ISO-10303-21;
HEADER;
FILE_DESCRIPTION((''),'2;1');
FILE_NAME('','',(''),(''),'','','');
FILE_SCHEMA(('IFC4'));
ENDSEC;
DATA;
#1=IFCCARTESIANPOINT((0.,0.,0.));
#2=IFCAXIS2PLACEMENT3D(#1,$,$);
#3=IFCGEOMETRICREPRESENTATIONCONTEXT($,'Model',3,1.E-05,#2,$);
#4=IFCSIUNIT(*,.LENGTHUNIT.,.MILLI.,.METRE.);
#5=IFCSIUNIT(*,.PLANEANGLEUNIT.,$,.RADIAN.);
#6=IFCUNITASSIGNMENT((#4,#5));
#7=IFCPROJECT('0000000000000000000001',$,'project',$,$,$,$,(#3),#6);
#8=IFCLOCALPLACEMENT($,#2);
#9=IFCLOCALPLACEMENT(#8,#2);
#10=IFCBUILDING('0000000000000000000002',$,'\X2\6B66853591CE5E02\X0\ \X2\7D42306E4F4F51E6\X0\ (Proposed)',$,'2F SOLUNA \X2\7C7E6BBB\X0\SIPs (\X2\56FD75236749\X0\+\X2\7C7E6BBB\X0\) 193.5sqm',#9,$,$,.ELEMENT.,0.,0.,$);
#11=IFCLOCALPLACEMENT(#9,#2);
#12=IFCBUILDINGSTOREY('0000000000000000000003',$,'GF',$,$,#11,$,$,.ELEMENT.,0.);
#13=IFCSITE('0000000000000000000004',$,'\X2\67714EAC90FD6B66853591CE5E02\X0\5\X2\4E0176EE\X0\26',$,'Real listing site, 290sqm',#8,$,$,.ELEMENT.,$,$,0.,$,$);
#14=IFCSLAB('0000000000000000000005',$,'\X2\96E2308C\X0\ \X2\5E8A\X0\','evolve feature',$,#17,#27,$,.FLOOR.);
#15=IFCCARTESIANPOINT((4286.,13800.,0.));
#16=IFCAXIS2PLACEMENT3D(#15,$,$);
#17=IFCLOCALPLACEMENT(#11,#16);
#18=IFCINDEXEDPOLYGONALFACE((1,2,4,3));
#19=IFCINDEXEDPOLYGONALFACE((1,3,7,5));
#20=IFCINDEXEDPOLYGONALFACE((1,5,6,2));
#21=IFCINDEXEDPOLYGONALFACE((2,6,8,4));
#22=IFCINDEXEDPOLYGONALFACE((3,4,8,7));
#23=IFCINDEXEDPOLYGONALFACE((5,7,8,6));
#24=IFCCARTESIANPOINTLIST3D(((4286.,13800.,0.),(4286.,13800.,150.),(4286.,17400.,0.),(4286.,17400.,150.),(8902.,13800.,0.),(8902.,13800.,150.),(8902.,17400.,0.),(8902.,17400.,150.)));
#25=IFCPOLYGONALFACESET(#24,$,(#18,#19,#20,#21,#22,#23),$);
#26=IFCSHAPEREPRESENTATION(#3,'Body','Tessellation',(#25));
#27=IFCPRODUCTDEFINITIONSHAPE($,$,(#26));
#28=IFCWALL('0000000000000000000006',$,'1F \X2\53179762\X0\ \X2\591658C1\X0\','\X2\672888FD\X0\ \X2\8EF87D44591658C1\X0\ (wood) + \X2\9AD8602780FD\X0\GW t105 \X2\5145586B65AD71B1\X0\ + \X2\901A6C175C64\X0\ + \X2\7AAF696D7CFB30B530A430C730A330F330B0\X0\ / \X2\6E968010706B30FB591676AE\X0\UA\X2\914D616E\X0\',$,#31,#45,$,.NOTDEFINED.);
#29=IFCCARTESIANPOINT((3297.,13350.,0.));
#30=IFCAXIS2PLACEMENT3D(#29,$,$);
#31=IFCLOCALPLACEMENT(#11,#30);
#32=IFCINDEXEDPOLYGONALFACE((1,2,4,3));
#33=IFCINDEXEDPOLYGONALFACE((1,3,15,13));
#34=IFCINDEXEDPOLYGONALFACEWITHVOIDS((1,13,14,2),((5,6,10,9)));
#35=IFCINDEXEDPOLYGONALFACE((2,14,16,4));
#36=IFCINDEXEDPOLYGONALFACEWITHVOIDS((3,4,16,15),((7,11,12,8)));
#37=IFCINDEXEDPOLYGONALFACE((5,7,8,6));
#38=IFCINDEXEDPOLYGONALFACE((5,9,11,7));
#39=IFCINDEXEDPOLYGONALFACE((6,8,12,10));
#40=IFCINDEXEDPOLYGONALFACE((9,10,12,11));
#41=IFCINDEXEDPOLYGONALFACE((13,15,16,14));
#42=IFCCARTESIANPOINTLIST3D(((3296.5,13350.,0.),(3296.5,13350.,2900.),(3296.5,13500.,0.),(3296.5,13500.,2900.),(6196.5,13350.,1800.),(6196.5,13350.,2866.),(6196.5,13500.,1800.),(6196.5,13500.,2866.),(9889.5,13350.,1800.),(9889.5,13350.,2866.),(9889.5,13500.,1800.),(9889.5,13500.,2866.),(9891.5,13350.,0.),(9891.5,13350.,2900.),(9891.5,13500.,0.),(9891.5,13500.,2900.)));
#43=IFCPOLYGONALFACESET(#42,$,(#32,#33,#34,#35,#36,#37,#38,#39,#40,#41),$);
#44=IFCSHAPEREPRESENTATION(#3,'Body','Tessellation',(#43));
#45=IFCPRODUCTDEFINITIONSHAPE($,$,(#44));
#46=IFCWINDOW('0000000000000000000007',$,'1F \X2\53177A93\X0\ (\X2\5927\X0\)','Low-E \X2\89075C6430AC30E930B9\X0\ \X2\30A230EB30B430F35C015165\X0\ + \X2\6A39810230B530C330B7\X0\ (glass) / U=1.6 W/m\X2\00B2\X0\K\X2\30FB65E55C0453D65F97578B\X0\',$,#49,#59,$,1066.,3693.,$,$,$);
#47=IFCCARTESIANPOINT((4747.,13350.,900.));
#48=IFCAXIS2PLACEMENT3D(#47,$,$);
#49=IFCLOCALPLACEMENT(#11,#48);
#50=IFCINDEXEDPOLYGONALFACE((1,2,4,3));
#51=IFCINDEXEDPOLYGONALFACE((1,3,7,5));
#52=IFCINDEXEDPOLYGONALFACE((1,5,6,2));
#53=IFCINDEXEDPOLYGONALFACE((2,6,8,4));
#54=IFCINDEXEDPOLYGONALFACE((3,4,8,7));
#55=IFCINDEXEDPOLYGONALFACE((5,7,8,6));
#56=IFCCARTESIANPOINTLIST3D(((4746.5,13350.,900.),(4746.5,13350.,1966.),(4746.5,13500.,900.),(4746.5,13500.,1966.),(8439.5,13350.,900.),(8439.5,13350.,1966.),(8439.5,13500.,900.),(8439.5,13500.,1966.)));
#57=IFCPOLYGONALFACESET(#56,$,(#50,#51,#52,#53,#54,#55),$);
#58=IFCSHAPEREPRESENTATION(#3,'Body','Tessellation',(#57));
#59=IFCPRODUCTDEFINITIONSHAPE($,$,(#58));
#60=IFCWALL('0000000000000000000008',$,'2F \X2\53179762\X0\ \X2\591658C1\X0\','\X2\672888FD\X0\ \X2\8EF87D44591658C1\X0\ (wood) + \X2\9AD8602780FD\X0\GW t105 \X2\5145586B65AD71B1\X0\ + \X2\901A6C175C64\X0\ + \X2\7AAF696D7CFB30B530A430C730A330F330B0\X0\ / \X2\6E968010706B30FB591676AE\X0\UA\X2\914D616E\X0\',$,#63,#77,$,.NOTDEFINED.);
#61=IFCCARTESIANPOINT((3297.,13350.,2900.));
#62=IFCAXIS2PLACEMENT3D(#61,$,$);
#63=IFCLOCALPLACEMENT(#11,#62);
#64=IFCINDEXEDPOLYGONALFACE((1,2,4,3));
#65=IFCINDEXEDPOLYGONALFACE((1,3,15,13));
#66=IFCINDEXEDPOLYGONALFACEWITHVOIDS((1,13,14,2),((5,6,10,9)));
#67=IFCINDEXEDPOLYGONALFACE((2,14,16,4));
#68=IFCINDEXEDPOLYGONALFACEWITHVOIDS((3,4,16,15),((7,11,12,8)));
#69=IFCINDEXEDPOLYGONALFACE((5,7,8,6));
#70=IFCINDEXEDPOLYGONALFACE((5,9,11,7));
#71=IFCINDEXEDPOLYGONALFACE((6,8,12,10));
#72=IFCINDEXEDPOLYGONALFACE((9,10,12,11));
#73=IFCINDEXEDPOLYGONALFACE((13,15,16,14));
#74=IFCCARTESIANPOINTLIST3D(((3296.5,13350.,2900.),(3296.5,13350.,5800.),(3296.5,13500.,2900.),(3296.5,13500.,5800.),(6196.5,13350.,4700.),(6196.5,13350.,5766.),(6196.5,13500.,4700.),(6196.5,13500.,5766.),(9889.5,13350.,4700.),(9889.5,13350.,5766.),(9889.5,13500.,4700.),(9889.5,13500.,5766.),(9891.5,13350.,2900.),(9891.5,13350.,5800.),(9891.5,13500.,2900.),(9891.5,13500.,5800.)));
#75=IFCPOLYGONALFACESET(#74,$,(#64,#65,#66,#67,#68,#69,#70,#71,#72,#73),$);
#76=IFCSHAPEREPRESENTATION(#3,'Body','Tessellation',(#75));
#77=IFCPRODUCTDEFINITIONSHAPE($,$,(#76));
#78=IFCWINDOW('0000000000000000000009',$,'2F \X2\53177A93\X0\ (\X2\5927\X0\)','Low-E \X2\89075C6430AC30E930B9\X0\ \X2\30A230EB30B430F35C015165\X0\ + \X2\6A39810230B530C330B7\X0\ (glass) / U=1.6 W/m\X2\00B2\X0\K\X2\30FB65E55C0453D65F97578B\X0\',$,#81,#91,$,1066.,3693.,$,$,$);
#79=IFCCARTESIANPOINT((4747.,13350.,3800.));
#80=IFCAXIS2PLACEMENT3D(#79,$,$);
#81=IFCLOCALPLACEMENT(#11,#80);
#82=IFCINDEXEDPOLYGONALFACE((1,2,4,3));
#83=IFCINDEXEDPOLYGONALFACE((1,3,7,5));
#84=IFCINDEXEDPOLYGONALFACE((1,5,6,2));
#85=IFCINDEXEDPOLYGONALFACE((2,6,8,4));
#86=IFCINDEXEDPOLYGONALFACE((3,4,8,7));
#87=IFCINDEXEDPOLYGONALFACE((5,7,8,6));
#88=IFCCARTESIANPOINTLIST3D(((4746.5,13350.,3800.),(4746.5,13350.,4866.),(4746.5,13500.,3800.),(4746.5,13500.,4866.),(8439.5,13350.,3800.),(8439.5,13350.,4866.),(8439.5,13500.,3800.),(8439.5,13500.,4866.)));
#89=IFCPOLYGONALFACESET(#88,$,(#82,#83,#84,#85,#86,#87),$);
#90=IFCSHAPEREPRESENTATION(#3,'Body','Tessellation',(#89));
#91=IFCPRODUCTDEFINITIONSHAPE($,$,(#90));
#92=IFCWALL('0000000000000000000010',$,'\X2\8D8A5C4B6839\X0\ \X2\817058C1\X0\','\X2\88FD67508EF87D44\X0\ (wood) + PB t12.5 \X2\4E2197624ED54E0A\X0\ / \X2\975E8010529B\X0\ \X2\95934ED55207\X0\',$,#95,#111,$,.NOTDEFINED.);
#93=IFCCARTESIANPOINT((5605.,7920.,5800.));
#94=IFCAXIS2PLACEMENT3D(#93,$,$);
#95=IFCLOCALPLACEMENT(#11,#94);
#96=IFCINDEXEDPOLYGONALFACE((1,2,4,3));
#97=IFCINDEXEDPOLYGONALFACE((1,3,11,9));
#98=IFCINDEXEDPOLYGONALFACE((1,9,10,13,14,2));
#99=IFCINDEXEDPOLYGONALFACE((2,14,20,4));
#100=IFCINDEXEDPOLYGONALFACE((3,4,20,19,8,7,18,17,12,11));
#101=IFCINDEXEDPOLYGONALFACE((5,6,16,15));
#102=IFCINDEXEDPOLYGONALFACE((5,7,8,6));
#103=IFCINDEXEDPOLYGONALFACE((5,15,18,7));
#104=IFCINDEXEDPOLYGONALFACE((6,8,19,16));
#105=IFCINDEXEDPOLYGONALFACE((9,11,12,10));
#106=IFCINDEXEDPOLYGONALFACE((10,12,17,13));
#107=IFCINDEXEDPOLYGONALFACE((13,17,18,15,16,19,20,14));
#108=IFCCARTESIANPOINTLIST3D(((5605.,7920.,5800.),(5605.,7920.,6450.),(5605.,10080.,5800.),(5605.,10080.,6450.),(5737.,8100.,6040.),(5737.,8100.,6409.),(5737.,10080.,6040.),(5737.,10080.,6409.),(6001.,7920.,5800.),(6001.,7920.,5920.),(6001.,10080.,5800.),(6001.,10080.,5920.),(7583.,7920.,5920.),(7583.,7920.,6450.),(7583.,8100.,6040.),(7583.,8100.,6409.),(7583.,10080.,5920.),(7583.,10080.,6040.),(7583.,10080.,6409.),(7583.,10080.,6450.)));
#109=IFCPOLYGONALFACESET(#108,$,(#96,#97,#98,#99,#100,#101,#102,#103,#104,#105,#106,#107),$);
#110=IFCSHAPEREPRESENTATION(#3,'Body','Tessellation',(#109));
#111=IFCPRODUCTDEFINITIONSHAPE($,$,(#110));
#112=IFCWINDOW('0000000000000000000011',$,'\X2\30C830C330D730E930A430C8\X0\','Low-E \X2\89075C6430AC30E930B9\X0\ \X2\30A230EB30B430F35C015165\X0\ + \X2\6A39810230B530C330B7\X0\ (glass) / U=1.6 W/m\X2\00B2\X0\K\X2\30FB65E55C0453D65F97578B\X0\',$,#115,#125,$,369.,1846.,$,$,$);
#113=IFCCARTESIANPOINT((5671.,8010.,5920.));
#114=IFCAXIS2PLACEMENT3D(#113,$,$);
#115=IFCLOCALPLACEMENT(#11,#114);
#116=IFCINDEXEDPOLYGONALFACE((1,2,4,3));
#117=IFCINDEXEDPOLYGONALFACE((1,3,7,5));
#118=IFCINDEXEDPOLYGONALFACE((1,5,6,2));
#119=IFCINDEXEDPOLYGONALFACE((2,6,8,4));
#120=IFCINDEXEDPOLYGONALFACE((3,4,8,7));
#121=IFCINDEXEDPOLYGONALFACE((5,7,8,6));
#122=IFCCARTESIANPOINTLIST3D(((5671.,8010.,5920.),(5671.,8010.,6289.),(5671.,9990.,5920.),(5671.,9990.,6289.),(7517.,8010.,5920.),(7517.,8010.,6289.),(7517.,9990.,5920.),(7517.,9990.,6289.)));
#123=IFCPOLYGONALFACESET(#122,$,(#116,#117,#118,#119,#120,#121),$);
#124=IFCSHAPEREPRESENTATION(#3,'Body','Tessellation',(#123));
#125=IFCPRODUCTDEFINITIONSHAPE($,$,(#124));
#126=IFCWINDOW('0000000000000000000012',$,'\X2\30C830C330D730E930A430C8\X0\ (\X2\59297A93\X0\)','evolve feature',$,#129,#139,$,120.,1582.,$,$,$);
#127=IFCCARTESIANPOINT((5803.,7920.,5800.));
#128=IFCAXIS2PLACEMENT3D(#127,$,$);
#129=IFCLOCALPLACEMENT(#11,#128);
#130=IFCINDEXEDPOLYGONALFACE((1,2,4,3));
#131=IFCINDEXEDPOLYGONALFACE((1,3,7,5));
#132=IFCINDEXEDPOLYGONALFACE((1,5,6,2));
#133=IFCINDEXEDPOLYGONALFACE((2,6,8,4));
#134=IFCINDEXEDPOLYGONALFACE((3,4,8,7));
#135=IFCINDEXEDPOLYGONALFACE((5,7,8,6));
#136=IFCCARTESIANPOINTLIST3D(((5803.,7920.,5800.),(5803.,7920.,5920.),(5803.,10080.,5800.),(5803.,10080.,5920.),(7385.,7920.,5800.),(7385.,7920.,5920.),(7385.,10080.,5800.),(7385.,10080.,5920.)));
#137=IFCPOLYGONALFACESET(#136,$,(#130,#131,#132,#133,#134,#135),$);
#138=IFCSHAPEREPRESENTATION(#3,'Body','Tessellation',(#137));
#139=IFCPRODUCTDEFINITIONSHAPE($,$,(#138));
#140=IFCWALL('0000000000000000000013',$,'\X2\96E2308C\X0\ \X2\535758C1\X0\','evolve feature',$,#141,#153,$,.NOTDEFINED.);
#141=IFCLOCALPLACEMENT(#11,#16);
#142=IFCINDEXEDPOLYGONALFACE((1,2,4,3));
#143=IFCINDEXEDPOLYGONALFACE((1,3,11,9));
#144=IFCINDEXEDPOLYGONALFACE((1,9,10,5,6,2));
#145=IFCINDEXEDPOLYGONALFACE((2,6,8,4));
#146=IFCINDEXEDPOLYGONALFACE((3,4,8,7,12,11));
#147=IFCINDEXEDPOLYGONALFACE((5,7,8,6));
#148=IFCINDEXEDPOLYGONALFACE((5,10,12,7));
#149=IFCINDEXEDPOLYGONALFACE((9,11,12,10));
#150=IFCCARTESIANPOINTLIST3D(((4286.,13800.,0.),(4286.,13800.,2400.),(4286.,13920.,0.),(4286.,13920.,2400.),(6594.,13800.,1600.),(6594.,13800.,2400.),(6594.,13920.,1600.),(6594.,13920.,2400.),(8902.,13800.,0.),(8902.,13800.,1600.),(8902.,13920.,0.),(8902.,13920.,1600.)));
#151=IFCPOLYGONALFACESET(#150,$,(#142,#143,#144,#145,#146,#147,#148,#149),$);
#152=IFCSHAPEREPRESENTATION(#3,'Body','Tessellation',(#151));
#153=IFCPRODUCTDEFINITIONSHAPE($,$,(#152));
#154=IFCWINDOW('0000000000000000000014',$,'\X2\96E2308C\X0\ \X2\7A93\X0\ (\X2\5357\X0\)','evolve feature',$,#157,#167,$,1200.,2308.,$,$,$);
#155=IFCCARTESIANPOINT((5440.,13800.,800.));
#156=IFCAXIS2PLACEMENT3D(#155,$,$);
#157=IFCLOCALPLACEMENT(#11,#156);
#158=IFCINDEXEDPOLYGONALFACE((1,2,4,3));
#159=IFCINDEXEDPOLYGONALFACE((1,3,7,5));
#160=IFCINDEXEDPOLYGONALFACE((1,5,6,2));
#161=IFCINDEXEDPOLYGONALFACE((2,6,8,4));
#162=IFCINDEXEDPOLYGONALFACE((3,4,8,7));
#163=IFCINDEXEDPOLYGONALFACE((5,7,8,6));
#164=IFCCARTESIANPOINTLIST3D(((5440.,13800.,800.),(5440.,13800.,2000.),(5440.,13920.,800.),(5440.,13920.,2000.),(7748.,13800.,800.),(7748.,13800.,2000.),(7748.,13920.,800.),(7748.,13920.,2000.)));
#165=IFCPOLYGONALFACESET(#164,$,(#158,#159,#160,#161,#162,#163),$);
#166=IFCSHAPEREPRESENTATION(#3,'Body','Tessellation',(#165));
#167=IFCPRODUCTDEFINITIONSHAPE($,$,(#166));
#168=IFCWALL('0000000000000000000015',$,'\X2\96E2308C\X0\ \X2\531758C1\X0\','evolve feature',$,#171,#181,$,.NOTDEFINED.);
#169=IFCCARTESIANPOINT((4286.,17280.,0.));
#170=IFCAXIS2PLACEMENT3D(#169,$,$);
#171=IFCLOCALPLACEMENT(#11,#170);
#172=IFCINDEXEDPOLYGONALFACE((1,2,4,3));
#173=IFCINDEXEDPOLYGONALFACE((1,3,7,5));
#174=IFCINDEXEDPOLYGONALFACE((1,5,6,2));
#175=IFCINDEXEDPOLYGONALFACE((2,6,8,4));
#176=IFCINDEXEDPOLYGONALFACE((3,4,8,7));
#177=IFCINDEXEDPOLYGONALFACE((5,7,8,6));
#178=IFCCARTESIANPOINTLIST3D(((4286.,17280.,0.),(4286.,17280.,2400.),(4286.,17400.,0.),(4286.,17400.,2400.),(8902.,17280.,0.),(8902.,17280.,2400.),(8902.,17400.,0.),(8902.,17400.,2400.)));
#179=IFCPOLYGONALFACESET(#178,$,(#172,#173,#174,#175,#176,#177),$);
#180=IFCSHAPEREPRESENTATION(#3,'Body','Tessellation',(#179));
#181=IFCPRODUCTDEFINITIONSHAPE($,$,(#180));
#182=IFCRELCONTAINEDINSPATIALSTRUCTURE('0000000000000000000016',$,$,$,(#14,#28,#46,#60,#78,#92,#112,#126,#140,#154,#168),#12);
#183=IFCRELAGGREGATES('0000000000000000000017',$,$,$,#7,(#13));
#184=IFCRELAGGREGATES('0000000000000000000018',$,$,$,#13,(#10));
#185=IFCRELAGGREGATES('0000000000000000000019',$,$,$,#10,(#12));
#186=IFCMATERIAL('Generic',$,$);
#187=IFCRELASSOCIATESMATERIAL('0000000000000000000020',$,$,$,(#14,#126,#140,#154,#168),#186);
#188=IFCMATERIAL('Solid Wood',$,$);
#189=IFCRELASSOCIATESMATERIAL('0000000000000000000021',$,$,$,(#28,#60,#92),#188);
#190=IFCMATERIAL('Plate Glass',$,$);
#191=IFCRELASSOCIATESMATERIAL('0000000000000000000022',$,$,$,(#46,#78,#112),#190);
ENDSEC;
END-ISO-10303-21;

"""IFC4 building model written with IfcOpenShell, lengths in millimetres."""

from ifc_helpers import new_model, si_unit, frame, frame_2d, origin, place, context, project, spatial, rectangle, extrude, material, element, fill, save


model = new_model("IFC4")

# Units and contexts
model_context = context("Model", 3, precision=1e-05, world=origin())
ifc_project = project(units=[si_unit("LENGTHUNIT", "METRE", prefix="MILLI"), si_unit("PLANEANGLEUNIT", "RADIAN")], contexts=[model_context])

# Site, building, storey
site_placement = place(None, origin())
site = spatial("IfcSite", under=ifc_project, at=site_placement, Name="東京都武蔵野市5丁目26", ObjectType="Real listing site, 290sqm", CompositionType="ELEMENT", RefElevation=0.0)
building_placement = place(site_placement, origin())
building = spatial("IfcBuilding", under=site, at=building_placement, Name="武蔵野市 終の住処 (Proposed)", ObjectType="2F SOLUNA 籾殻SIPs (国産杉+籾殻) 193.5sqm", CompositionType="ELEMENT", ElevationOfRefHeight=0.0, ElevationOfTerrain=0.0)
storey_placement = place(building_placement, origin())
storey = spatial("IfcBuildingStorey", under=building, at=storey_placement, Name="GF", CompositionType="ELEMENT", Elevation=0.0)

# Slab
ifc_material_1 = material(Name="Generic")
slab_placement = place(storey_placement, frame((4286.0, 13800.0, 0.0)))
element("IfcSlab", 1, at=slab_placement, inside=storey, material=ifc_material_1, Name="離れ 床", Description="evolve feature", PredefinedType="FLOOR", context=model_context, shape_type="SweptSolid", body=[
    extrude(rectangle(XDim=4616.0, YDim=3600.0, at=frame_2d((2308.0, 1800.0))), frame((4286.0, 13800.0, 0.0)), (0.0, 0.0, 1.0), 150.0),
])

# Wall, opening, window
ifc_material_2 = material(Name="Solid Wood")
wall_1_placement = place(storey_placement, frame((3297.0, 13350.0, 0.0)))
wall_1 = element("IfcWall", 2, at=wall_1_placement, inside=storey, material=ifc_material_2, Name="1F 北面 外壁", Description="木製 軸組外壁 (wood) + 高性能GW t105 充填断熱 + 通気層 + 窯業系サイディング / 準耐火・外皮UA配慮", PredefinedType="NOTDEFINED", context=model_context, shape_type="SweptSolid", body=[
    extrude(rectangle(XDim=6595.0, YDim=150.0, at=frame_2d((3297.0, 75.0))), frame((3297.0, 13350.0, 0.0)), (0.0, 0.0, 1.0), 2900.0),
])
opening_1_placement = place(storey_placement, frame((4747.0, 13350.0, 900.0)))
opening_1 = element("IfcOpeningElement", 3, at=opening_1_placement, cuts=wall_1, PredefinedType="NOTDEFINED", context=model_context, shape_type="SweptSolid", body=[
    extrude(rectangle(XDim=3693.0, YDim=150.0, at=frame_2d((1846.0, 75.0))), frame((4747.0, 13350.0, 900.0)), (0.0, 0.0, 1.0), 1066.0),
])
ifc_material_3 = material(Name="Plate Glass")
window_1_placement = place(storey_placement, frame((4747.0, 13350.0, 900.0)))
window_1 = element("IfcWindow", 4, at=window_1_placement, inside=storey, material=ifc_material_3, Name="1F 北窓 (大)", Description="Low-E 複層ガラス アルゴン封入 + 樹脂サッシ (glass) / U=1.6 W/m²K・日射取得型", OverallHeight=1066.0, OverallWidth=3693.0, context=model_context, shape_type="SweptSolid", body=[
    extrude(rectangle(XDim=3693.0, YDim=150.0, at=frame_2d((1846.0, 75.0))), frame((4747.0, 13350.0, 900.0)), (0.0, 0.0, 1.0), 1066.0),
])
fill(opening_1, window_1)

# Wall, opening, window
wall_2_placement = place(storey_placement, frame((3297.0, 13350.0, 2900.0)))
wall_2 = element("IfcWall", 5, at=wall_2_placement, inside=storey, material=ifc_material_2, Name="2F 北面 外壁", Description="木製 軸組外壁 (wood) + 高性能GW t105 充填断熱 + 通気層 + 窯業系サイディング / 準耐火・外皮UA配慮", PredefinedType="NOTDEFINED", context=model_context, shape_type="SweptSolid", body=[
    extrude(rectangle(XDim=6595.0, YDim=150.0, at=frame_2d((3297.0, 75.0))), frame((3297.0, 13350.0, 2900.0)), (0.0, 0.0, 1.0), 2900.0),
])
opening_2_placement = place(storey_placement, frame((4747.0, 13350.0, 3800.0)))
opening_2 = element("IfcOpeningElement", 6, at=opening_2_placement, cuts=wall_2, PredefinedType="NOTDEFINED", context=model_context, shape_type="SweptSolid", body=[
    extrude(rectangle(XDim=3693.0, YDim=150.0, at=frame_2d((1846.0, 75.0))), frame((4747.0, 13350.0, 3800.0)), (0.0, 0.0, 1.0), 1066.0),
])
window_2_placement = place(storey_placement, frame((4747.0, 13350.0, 3800.0)))
window_2 = element("IfcWindow", 7, at=window_2_placement, inside=storey, material=ifc_material_3, Name="2F 北窓 (大)", Description="Low-E 複層ガラス アルゴン封入 + 樹脂サッシ (glass) / U=1.6 W/m²K・日射取得型", OverallHeight=1066.0, OverallWidth=3693.0, context=model_context, shape_type="SweptSolid", body=[
    extrude(rectangle(XDim=3693.0, YDim=150.0, at=frame_2d((1846.0, 75.0))), frame((4747.0, 13350.0, 3800.0)), (0.0, 0.0, 1.0), 1066.0),
])
fill(opening_2, window_2)

# Wall, openings, windows
wall_3_placement = place(storey_placement, frame((5605.0, 7920.0, 5800.0)))
wall_3 = element("IfcWall", 8, at=wall_3_placement, inside=storey, material=ifc_material_2, Name="越屋根 腰壁", Description="製材軸組 (wood) + PB t12.5 両面仕上 / 非耐力 間仕切", PredefinedType="NOTDEFINED", context=model_context, shape_type="SweptSolid", body=[
    extrude(rectangle(XDim=1978.0, YDim=2160.0, at=frame_2d((989.0, 1080.0))), frame((5605.0, 7920.0, 5800.0)), (0.0, 0.0, 1.0), 650.0),
])
opening_3_placement = place(storey_placement, frame((5671.0, 8010.0, 5920.0)))
opening_3 = element("IfcOpeningElement", 9, at=opening_3_placement, cuts=wall_3, PredefinedType="NOTDEFINED", context=model_context, shape_type="SweptSolid", body=[
    extrude(rectangle(XDim=1846.0, YDim=1980.0, at=frame_2d((923.0, 990.0))), frame((5671.0, 8010.0, 5920.0)), (0.0, 0.0, 1.0), 369.0),
])
opening_4_placement = place(storey_placement, frame((5803.0, 7920.0, 5800.0)))
opening_4 = element("IfcOpeningElement", 10, at=opening_4_placement, cuts=wall_3, PredefinedType="NOTDEFINED", context=model_context, shape_type="SweptSolid", body=[
    extrude(rectangle(XDim=1582.0, YDim=2160.0, at=frame_2d((791.0, 1080.0))), frame((5803.0, 7920.0, 5800.0)), (0.0, 0.0, 1.0), 120.0),
])
window_3_placement = place(storey_placement, frame((5671.0, 8010.0, 5920.0)))
window_3 = element("IfcWindow", 11, at=window_3_placement, inside=storey, material=ifc_material_3, Name="トップライト", Description="Low-E 複層ガラス アルゴン封入 + 樹脂サッシ (glass) / U=1.6 W/m²K・日射取得型", OverallHeight=369.0, OverallWidth=1846.0, context=model_context, shape_type="SweptSolid", body=[
    extrude(rectangle(XDim=1846.0, YDim=1980.0, at=frame_2d((923.0, 990.0))), frame((5671.0, 8010.0, 5920.0)), (0.0, 0.0, 1.0), 369.0),
])
fill(opening_3, window_3)
window_4_placement = place(storey_placement, frame((5803.0, 7920.0, 5800.0)))
window_4 = element("IfcWindow", 12, at=window_4_placement, inside=storey, material=ifc_material_1, Name="トップライト (天窓)", Description="evolve feature", OverallHeight=120.0, OverallWidth=1582.0, context=model_context, shape_type="SweptSolid", body=[
    extrude(rectangle(XDim=1582.0, YDim=2160.0, at=frame_2d((791.0, 1080.0))), frame((5803.0, 7920.0, 5800.0)), (0.0, 0.0, 1.0), 120.0),
])
fill(opening_4, window_4)

# Wall, opening, window
wall_4_placement = place(storey_placement, frame((4286.0, 13800.0, 0.0)))
wall_4 = element("IfcWall", 13, at=wall_4_placement, inside=storey, material=ifc_material_1, Name="離れ 南壁", Description="evolve feature", PredefinedType="NOTDEFINED", context=model_context, shape_type="SweptSolid", body=[
    extrude(rectangle(XDim=4616.0, YDim=120.0, at=frame_2d((2308.0, 60.0))), frame((4286.0, 13800.0, 0.0)), (0.0, 0.0, 1.0), 2400.0),
])
opening_5_placement = place(storey_placement, frame((5440.0, 13800.0, 800.0)))
opening_5 = element("IfcOpeningElement", 14, at=opening_5_placement, cuts=wall_4, PredefinedType="NOTDEFINED", context=model_context, shape_type="SweptSolid", body=[
    extrude(rectangle(XDim=2308.0, YDim=120.0, at=frame_2d((1154.0, 60.0))), frame((5440.0, 13800.0, 800.0)), (0.0, 0.0, 1.0), 1200.0),
])
window_5_placement = place(storey_placement, frame((5440.0, 13800.0, 800.0)))
window_5 = element("IfcWindow", 15, at=window_5_placement, inside=storey, material=ifc_material_1, Name="離れ 窓 (南)", Description="evolve feature", OverallHeight=1200.0, OverallWidth=2308.0, context=model_context, shape_type="SweptSolid", body=[
    extrude(rectangle(XDim=2308.0, YDim=120.0, at=frame_2d((1154.0, 60.0))), frame((5440.0, 13800.0, 800.0)), (0.0, 0.0, 1.0), 1200.0),
])
fill(opening_5, window_5)

# Wall
wall_5_placement = place(storey_placement, frame((4286.0, 17280.0, 0.0)))
element("IfcWall", 16, at=wall_5_placement, inside=storey, material=ifc_material_1, Name="離れ 北壁", Description="evolve feature", PredefinedType="NOTDEFINED", context=model_context, shape_type="SweptSolid", body=[
    extrude(rectangle(XDim=4616.0, YDim=120.0, at=frame_2d((2308.0, 60.0))), frame((4286.0, 17280.0, 0.0)), (0.0, 0.0, 1.0), 2400.0),
])

save(model, "model.ifc")
